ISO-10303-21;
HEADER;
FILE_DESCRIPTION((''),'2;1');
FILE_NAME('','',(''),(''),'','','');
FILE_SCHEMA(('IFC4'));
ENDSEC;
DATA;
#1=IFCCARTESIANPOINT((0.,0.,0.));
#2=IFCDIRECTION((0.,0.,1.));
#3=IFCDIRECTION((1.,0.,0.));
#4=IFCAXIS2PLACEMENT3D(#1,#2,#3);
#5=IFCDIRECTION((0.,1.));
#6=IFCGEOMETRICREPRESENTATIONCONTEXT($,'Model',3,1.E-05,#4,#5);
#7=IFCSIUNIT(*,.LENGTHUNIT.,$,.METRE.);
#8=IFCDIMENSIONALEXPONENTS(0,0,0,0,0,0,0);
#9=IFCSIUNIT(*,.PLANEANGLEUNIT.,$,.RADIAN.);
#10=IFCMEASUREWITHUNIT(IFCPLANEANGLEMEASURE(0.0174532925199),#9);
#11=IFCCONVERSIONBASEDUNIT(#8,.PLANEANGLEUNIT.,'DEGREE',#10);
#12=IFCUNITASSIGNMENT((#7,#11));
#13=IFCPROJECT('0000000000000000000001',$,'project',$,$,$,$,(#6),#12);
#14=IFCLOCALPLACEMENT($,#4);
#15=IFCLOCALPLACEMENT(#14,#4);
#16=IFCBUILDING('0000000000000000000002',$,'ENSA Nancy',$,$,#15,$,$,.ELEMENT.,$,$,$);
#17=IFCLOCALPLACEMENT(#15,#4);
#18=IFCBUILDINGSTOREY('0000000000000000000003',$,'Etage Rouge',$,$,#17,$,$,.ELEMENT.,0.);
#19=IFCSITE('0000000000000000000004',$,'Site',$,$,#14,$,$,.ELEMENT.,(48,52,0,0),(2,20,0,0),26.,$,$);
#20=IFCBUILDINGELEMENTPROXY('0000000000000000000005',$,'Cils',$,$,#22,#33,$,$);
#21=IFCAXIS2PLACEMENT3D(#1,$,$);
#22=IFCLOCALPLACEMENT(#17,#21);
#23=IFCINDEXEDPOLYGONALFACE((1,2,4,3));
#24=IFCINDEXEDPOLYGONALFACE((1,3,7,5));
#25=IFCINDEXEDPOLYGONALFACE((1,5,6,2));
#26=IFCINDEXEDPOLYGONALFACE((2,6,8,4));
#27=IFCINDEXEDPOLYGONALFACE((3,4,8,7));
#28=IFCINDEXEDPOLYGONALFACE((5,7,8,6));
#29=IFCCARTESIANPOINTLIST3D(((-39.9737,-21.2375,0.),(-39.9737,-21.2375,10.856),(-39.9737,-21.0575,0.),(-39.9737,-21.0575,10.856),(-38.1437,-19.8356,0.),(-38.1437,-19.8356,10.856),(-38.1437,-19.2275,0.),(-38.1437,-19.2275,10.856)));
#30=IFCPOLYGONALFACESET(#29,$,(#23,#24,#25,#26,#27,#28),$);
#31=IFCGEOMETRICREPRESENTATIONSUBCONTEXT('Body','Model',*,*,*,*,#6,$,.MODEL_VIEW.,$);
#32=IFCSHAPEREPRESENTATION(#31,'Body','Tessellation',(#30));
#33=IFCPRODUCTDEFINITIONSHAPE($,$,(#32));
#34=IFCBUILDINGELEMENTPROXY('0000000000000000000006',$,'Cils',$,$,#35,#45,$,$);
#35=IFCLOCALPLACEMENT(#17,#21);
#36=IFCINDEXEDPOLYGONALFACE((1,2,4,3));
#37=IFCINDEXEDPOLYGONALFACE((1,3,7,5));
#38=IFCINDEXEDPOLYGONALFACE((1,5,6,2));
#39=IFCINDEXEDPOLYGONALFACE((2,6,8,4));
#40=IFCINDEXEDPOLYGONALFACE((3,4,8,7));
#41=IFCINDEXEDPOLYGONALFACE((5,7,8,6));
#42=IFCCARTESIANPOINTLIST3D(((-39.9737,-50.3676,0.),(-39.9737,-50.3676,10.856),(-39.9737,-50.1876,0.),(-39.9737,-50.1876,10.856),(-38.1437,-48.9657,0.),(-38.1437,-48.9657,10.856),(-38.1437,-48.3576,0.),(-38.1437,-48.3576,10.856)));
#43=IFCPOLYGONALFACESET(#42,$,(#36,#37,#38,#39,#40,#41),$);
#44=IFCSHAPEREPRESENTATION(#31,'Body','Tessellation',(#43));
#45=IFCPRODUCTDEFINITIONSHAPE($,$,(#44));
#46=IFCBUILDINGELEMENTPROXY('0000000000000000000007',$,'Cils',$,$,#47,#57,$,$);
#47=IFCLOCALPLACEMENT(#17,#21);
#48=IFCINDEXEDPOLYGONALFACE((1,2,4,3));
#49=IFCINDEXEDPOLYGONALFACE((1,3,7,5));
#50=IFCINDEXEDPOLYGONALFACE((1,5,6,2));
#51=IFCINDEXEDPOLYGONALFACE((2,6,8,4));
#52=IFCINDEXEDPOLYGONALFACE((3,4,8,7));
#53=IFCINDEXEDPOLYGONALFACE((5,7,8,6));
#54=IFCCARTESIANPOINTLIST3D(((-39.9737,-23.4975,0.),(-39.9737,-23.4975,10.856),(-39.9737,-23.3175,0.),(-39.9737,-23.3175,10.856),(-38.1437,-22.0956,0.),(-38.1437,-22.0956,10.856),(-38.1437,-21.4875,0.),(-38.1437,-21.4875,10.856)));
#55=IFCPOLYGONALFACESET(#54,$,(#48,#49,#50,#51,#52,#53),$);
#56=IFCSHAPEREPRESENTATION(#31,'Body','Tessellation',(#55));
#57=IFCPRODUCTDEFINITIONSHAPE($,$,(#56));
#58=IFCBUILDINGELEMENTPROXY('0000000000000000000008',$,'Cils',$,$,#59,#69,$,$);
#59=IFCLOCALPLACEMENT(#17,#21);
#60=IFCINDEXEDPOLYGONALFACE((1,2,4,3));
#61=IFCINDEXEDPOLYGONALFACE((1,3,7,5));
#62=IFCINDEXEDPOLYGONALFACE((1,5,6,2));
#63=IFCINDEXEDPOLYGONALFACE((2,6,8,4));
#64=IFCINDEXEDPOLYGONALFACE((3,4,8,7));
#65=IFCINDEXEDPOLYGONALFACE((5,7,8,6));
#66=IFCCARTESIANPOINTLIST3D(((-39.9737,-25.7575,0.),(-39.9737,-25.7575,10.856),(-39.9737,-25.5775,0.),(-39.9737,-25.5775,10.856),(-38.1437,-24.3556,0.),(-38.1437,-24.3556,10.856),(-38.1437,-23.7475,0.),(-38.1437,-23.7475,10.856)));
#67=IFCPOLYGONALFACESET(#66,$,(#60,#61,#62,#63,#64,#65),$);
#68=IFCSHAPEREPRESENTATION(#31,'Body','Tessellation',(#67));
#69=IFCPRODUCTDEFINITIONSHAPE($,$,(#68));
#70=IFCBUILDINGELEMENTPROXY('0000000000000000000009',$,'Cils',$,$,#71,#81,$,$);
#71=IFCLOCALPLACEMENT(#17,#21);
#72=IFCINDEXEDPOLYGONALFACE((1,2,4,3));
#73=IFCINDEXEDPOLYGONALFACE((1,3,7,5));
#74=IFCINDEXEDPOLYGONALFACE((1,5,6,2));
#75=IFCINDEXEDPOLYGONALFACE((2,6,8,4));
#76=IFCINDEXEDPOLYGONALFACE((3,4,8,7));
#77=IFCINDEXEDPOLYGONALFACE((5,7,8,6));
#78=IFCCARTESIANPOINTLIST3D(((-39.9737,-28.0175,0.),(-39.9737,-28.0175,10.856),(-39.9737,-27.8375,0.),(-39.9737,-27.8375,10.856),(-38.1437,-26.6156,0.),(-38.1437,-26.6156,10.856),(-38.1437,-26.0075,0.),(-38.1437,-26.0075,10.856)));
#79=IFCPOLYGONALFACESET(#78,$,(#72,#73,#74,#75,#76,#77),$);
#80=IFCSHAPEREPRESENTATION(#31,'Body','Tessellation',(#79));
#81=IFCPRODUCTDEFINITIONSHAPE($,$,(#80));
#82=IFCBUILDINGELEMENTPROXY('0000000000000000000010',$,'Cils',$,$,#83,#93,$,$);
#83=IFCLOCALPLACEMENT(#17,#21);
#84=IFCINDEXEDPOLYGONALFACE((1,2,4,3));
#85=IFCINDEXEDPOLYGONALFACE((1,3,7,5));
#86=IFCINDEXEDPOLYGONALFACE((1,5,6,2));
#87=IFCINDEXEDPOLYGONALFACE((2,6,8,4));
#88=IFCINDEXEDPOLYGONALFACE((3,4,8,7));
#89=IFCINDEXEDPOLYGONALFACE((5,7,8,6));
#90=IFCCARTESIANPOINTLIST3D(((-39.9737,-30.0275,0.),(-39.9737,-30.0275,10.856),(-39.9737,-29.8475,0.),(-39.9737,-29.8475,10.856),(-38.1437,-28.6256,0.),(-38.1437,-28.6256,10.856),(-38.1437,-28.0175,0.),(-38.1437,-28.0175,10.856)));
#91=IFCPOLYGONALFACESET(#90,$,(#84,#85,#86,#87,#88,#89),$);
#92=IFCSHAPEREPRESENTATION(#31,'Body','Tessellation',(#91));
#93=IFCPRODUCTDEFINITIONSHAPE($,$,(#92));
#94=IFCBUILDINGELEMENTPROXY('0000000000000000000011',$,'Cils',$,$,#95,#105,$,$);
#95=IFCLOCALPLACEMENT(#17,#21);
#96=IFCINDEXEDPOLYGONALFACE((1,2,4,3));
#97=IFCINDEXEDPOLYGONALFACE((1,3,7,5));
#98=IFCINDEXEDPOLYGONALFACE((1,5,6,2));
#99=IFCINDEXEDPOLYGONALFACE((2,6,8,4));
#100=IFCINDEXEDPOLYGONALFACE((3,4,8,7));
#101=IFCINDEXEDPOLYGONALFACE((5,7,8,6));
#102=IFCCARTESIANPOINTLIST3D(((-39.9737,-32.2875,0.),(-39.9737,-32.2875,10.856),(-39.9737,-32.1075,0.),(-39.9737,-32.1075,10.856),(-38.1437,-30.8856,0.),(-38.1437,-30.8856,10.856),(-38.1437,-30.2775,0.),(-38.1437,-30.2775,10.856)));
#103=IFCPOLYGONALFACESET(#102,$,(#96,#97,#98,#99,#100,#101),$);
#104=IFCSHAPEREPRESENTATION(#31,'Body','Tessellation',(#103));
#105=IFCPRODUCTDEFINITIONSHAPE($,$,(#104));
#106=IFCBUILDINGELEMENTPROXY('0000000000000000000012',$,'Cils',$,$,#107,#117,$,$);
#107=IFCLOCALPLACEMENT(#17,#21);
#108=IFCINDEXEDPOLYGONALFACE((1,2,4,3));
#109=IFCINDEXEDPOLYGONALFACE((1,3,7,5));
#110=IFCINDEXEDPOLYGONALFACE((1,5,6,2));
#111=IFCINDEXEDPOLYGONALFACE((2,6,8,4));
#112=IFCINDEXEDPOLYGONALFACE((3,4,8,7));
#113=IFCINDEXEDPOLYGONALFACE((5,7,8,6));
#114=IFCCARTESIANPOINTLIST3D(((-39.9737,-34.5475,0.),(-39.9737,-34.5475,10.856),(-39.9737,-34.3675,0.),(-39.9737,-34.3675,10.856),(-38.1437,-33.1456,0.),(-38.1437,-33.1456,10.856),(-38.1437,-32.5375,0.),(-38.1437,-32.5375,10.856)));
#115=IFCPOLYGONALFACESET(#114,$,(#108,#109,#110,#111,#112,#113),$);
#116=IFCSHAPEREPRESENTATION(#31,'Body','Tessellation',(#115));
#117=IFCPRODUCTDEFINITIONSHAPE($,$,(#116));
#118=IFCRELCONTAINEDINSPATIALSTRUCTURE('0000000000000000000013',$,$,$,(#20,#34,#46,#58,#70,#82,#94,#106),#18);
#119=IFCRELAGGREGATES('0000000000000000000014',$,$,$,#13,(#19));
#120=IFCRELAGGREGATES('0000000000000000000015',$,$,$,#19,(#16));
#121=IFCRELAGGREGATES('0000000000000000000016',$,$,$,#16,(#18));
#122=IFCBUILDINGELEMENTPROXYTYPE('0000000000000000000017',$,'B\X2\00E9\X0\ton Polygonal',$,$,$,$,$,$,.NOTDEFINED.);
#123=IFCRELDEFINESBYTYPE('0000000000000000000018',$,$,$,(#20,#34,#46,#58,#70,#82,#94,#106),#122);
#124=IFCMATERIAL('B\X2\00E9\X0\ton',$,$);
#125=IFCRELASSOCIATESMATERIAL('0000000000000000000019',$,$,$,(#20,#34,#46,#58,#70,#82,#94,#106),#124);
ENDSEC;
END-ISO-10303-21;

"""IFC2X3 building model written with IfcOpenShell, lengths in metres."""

from ifc_helpers import new_model, entity, si_unit, converted_unit, direction, frame, origin_with_axes, place, context, subcontext, project, spatial, polyline, outline, extrude, material, type_object, element, save


model = new_model("IFC2X3")

# Units and contexts
model_context = context("Model", 3, precision=1e-05, world=origin_with_axes(), true_north=direction((0.0, 1.0)))
body_context = subcontext(model_context, "Body", "Model", "MODEL_VIEW")
ifc_project = project(units=[si_unit("LENGTHUNIT", "METRE"), converted_unit("PLANEANGLEUNIT", "DEGREE", entity("IfcPlaneAngleMeasure", 0.0174532925199), si_unit("PLANEANGLEUNIT", "RADIAN"), dimensions=[0, 0, 0, 0, 0, 0, 0])], contexts=[model_context])

# Site, building, storey
site_placement = place(None, origin_with_axes())
site = spatial("IfcSite", under=ifc_project, at=site_placement, Name="Site", CompositionType="ELEMENT", RefLatitude=(48, 52, 0, 0), RefLongitude=(2, 20, 0, 0), RefElevation=26.0)
building_placement = place(site_placement, origin_with_axes())
building = spatial("IfcBuilding", under=site, at=building_placement, Name="ENSA Nancy", CompositionType="ELEMENT")
storey_placement = place(building_placement, origin_with_axes())
storey = spatial("IfcBuildingStorey", under=building, at=storey_placement, Name="Etage Rouge", CompositionType="ELEMENT", Elevation=0.0)

# Shared definitions
ifc_material = material(Name="Béton")

# Building element proxies
building_element_proxy_type = type_object("IfcBuildingElementProxyType", Name="Béton Polygonal", PredefinedType="NOTDEFINED")
for number, where, z_axis, x_axis, name in (
    (1, (-38.1437, -19.2275, 0.0), (0.0, 0.0, 1.0), (-0.707107, -0.707107, 0.0), "Cils"),
    (2, (-38.1437, -48.3576, 0.0), (0.0, 0.0, 1.0), (-0.707107, -0.707107, 0.0), "Cils"),
    (3, (-38.1437, -21.4875, 0.0), (0.0, 0.0, 1.0), (-0.707107, -0.707107, 0.0), "Cils"),
    (4, (-38.1437, -23.7475, 0.0), (0.0, 0.0, 1.0), (-0.707107, -0.707107, 0.0), "Cils"),
    (5, (-38.1437, -26.0075, 0.0), (0.0, 0.0, 1.0), (-0.707107, -0.707107, 0.0), "Cils"),
    (6, (-38.1437, -28.0175, 0.0), (0.0, 0.0, 1.0), (-0.707107, -0.707107, 0.0), "Cils"),
    (7, (-38.1437, -30.2775, 0.0), (0.0, 0.0, 1.0), (-0.707107, -0.707107, 0.0), "Cils"),
    (8, (-38.1437, -32.5375, 0.0), (0.0, 0.0, 1.0), (-0.707107, -0.707107, 0.0), "Cils"),
):
    element("IfcBuildingElementProxy", number, at=place(storey_placement, frame(where, z_axis=z_axis, x_axis=x_axis)), inside=storey, type_object=building_element_proxy_type, material=ifc_material, Name=name, context=body_context, shape_type="SweptSolid", body=[
        extrude(outline(polyline([(0.0, 0.0), (2.588, 0.0), (2.7153, 0.1273), (0.43, 0.43), (0.0, 0.0)])), origin_with_axes(), (0.0, 0.0, 1.0), 10.856),
    ])

save(model, "model.ifc")
